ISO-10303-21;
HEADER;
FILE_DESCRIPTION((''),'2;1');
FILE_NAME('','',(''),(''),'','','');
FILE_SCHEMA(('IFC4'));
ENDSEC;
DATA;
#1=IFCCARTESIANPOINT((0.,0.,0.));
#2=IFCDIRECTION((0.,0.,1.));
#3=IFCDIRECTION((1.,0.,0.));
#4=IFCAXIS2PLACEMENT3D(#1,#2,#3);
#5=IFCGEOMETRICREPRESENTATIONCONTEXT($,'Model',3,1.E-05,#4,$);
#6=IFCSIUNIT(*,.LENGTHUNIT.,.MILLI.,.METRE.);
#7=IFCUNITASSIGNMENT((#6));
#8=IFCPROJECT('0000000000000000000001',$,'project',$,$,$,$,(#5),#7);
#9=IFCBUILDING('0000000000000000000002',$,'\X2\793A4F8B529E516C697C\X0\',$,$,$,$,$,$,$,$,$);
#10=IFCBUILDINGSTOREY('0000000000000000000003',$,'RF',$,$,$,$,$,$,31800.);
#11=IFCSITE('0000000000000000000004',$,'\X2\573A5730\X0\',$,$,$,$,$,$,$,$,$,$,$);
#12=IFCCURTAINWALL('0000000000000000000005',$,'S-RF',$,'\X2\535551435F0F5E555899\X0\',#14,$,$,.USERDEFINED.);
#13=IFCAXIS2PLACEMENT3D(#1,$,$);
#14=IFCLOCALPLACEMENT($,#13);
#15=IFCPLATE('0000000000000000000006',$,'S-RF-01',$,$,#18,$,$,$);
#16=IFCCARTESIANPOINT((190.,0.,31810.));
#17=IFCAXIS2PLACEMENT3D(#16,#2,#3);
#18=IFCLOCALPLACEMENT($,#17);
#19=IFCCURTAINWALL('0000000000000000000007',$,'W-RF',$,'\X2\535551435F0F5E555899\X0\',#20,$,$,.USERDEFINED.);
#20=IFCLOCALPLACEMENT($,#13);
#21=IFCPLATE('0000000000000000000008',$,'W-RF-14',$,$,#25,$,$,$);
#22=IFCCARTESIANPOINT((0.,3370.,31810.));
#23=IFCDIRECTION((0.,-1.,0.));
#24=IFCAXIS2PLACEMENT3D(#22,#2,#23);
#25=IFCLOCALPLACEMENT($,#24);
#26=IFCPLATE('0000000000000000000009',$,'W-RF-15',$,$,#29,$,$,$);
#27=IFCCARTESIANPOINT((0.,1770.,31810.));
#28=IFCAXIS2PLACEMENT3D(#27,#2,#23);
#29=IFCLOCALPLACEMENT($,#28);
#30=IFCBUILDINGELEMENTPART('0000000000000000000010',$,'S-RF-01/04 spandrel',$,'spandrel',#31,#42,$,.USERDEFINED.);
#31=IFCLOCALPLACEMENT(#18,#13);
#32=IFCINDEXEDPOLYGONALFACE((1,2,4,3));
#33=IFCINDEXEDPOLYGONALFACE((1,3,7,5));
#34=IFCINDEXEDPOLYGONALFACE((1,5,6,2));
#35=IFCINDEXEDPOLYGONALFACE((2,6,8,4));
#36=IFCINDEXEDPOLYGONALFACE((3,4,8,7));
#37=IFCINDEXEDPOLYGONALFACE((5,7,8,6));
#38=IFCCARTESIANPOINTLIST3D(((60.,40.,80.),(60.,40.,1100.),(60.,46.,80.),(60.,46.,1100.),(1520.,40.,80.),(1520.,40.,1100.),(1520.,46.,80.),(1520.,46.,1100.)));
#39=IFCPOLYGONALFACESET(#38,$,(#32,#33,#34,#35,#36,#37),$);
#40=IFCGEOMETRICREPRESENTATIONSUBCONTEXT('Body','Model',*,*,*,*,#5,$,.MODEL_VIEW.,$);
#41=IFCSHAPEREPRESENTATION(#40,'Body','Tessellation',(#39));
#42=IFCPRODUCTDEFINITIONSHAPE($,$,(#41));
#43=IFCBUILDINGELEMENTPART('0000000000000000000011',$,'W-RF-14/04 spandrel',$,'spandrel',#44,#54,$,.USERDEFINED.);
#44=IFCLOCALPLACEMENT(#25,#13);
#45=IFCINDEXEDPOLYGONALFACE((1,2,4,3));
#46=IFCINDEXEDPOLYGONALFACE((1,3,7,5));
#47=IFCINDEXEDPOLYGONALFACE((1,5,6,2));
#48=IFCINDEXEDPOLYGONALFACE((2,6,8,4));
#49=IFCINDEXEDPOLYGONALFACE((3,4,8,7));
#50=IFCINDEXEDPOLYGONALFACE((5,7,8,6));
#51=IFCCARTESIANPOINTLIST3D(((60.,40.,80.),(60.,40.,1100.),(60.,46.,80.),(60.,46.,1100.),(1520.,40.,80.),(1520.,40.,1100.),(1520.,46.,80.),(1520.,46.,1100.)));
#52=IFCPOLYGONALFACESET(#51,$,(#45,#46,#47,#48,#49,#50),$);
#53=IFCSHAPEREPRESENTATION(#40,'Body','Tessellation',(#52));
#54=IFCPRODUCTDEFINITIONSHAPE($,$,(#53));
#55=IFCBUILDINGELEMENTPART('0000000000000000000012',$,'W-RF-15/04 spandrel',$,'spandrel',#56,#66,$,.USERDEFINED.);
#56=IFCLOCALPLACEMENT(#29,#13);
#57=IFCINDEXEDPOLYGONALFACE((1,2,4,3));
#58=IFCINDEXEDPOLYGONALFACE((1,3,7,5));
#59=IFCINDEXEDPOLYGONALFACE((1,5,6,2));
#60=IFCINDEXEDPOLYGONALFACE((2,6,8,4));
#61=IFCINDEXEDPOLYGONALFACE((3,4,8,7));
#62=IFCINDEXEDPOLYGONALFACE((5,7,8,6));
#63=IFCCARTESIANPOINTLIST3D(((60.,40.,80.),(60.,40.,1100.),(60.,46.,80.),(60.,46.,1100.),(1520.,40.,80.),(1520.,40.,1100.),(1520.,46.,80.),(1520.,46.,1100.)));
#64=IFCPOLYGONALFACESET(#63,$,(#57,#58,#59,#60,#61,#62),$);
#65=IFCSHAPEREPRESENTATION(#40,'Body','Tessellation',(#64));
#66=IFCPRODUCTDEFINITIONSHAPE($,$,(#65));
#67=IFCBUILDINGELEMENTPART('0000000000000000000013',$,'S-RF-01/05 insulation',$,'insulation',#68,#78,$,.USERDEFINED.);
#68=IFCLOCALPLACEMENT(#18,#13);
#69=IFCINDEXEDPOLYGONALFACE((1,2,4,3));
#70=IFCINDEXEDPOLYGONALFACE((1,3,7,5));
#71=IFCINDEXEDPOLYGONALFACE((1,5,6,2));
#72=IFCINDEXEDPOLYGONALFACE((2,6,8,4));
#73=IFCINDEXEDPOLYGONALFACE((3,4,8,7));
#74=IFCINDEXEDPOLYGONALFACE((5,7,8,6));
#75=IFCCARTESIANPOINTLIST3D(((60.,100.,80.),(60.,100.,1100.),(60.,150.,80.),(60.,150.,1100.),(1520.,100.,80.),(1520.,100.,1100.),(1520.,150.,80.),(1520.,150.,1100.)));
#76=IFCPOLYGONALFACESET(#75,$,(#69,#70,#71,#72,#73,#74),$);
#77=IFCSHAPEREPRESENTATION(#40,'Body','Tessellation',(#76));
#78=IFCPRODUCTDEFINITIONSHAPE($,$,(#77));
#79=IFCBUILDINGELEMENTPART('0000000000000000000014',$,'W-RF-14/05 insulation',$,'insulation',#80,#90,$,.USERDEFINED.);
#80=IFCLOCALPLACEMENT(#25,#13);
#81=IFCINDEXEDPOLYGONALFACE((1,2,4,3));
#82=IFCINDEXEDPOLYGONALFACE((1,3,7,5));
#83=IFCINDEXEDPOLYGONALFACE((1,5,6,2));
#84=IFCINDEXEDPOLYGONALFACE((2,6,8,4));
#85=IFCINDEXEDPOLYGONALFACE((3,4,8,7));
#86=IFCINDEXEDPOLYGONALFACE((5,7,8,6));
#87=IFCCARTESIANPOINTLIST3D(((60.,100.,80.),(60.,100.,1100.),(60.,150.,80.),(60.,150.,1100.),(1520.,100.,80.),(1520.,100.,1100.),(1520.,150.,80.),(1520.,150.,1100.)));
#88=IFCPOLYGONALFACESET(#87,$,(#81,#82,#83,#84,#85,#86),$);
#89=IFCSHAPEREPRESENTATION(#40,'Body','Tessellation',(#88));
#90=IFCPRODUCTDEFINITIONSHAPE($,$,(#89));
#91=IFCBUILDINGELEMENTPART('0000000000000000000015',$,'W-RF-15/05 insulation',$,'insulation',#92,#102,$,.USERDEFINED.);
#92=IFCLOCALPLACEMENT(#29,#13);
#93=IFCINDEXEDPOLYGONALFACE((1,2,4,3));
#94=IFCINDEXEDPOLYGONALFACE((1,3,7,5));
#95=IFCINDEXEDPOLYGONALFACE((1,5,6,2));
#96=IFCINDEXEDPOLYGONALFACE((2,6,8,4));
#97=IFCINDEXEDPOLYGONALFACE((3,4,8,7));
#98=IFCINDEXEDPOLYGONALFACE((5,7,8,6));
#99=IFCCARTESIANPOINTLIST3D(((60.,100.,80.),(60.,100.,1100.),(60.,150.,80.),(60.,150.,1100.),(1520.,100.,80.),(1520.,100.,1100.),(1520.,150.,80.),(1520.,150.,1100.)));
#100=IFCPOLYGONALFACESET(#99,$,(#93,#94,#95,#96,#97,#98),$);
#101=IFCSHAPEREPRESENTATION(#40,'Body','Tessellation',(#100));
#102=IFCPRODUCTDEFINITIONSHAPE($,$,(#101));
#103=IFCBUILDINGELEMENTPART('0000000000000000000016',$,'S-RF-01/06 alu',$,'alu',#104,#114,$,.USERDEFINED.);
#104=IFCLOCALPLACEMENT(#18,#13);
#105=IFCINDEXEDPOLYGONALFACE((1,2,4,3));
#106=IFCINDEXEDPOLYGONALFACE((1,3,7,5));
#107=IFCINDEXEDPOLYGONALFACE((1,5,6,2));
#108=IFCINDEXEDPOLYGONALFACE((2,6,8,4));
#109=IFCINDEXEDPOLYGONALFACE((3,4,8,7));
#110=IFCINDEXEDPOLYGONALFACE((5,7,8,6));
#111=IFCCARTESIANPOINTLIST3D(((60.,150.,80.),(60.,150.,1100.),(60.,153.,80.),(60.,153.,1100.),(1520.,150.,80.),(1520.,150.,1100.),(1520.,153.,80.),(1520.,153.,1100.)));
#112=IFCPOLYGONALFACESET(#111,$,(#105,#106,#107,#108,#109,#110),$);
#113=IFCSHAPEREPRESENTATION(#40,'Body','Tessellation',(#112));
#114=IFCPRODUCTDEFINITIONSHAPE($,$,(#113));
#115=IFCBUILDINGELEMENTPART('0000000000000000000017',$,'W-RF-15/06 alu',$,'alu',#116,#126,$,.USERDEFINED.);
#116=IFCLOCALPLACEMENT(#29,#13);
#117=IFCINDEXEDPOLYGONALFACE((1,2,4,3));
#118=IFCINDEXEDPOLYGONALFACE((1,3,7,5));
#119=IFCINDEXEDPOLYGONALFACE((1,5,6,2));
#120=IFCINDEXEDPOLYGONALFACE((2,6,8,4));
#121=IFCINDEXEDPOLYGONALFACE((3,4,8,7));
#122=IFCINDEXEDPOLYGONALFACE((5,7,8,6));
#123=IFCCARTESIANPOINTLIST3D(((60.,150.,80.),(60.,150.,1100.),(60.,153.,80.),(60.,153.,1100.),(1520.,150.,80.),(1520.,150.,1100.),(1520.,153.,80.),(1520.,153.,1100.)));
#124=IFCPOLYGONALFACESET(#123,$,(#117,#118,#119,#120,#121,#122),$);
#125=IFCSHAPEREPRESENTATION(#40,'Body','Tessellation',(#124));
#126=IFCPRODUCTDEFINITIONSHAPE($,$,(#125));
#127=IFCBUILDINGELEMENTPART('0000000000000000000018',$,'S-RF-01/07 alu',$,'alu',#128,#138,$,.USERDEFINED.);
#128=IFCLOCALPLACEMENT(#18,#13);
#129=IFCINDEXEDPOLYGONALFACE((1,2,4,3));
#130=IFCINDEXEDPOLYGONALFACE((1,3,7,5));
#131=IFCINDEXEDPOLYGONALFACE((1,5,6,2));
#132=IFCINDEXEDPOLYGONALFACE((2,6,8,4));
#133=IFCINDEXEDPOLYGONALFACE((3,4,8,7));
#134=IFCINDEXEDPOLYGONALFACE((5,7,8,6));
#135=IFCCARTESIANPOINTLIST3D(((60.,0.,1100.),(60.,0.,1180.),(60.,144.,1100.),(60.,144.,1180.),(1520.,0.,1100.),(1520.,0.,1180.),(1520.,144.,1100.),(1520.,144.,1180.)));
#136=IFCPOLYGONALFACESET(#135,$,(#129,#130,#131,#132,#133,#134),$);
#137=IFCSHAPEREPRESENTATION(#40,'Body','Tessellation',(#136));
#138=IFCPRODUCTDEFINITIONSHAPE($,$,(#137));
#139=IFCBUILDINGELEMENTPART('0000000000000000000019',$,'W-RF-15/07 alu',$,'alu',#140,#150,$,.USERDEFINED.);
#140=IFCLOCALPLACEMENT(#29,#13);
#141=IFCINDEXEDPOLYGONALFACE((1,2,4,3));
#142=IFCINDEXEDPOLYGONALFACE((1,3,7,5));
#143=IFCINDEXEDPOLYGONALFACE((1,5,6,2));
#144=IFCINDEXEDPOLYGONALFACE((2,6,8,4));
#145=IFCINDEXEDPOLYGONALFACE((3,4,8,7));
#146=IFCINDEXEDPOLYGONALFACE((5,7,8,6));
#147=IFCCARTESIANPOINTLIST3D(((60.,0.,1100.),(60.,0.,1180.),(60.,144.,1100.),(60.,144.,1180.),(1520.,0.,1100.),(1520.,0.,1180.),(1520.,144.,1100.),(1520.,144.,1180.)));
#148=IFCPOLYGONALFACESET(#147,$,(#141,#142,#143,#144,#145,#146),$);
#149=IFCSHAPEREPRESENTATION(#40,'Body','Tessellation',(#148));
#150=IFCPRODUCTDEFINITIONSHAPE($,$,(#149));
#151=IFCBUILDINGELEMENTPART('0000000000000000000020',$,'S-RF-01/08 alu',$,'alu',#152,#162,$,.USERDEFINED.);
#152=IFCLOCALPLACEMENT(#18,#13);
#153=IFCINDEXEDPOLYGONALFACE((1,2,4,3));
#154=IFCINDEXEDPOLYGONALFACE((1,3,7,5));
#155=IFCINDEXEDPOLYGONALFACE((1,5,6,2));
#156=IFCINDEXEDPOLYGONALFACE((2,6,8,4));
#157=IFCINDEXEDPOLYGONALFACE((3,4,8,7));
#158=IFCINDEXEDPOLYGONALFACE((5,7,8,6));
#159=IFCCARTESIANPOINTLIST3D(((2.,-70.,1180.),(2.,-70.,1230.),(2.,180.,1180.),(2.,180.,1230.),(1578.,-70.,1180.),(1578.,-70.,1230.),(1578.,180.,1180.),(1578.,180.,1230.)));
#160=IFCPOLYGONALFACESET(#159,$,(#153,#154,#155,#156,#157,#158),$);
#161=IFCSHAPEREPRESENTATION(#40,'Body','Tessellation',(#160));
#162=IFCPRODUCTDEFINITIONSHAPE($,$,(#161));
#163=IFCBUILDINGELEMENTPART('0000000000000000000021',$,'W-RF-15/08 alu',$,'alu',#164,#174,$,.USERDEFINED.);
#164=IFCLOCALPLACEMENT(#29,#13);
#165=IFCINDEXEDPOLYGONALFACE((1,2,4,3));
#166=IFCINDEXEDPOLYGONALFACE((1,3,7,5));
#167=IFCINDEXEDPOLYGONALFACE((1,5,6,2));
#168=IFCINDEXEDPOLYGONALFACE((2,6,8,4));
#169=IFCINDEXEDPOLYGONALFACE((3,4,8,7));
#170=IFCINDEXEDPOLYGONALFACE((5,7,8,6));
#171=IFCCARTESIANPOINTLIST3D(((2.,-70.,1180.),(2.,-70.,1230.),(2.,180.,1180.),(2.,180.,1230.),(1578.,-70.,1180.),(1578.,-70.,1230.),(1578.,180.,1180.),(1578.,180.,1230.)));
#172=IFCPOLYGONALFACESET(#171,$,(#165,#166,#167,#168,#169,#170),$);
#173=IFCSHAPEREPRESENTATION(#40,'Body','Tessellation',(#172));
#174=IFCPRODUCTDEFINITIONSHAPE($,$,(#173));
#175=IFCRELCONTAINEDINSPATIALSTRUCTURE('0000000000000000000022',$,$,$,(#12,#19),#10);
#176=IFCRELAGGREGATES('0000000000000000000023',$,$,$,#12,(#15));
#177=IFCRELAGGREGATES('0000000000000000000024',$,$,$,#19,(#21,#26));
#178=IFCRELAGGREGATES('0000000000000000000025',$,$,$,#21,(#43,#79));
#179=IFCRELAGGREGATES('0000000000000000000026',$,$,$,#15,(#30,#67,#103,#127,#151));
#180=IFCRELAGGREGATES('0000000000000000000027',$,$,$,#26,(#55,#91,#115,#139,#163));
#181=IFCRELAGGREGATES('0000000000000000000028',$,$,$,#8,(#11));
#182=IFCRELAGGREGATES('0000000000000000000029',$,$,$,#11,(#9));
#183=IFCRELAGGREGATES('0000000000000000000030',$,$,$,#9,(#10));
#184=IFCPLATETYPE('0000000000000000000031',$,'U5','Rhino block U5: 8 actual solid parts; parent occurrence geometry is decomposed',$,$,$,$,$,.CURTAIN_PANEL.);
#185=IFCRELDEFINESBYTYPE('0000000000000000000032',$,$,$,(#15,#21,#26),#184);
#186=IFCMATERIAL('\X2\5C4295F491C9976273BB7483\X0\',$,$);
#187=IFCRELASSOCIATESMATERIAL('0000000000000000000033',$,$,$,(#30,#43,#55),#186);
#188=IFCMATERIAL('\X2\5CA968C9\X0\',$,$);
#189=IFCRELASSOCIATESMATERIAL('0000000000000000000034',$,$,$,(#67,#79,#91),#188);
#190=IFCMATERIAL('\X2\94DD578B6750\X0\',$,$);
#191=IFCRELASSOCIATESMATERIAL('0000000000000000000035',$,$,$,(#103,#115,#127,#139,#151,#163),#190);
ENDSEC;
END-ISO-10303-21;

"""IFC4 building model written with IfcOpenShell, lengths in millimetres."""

from ifc_helpers import new_model, si_unit, frame, frame_2d, origin, origin_with_axes, place, context, subcontext, project, spatial, rectangle, extrude, source, transform, mapped, material, type_object, element, aggregate, save


model = new_model("IFC4")

# Units and contexts
model_context = context("Model", 3, precision=1e-05, world=origin_with_axes())
body_context = subcontext(model_context, "Body", "Model", "MODEL_VIEW")
ifc_project = project(units=[si_unit("LENGTHUNIT", "METRE", prefix="MILLI")], contexts=[model_context])

# Site, building, storey
site = spatial("IfcSite", under=ifc_project, Name="场地")
building = spatial("IfcBuilding", under=site, Name="示例办公楼")
storey = spatial("IfcBuildingStorey", under=building, Name="RF", Elevation=31800.0)

# Curtain walls, plates
curtain_wall_1 = element("IfcCurtainWall", 1, inside=storey, Name="S-RF", ObjectType="单元式幕墙", PredefinedType="USERDEFINED")
plate_type = type_object("IfcPlateType", Name="U5", Description="Rhino block U5: 8 actual solid parts; parent occurrence geometry is decomposed", PredefinedType="CURTAIN_PANEL")
plate_1_placement = place(None, frame((190.0, 0.0, 31810.0), z_axis=(0.0, 0.0, 1.0), x_axis=(1.0, 0.0, 0.0)))
plate_1 = element("IfcPlate", 2, at=plate_1_placement, type_object=plate_type, Name="S-RF-01")
ifc_material_1 = material(Name="铝型材")
aggregate(curtain_wall_1, [plate_1])
curtain_wall_2 = element("IfcCurtainWall", 3, inside=storey, Name="W-RF", ObjectType="单元式幕墙", PredefinedType="USERDEFINED")
plate_2_placement = place(None, frame((0.0, 3370.0, 31810.0), z_axis=(0.0, 0.0, 1.0), x_axis=(0.0, -1.0, 0.0)))
plate_2 = element("IfcPlate", 4, at=plate_2_placement, type_object=plate_type, Name="W-RF-14")
plate_3_placement = place(None, frame((0.0, 1770.0, 31810.0), z_axis=(0.0, 0.0, 1.0), x_axis=(0.0, -1.0, 0.0)))
plate_3 = element("IfcPlate", 5, at=plate_3_placement, type_object=plate_type, Name="W-RF-15")
aggregate(curtain_wall_2, [plate_2, plate_3])

# Building element parts
ifc_material_2 = material(Name="层间釉面玻璃")
shared_shape_1 = source(origin(), body_context, "Body", "SweptSolid", [
    extrude(rectangle(XDim=1460.0, YDim=6.0, at=frame_2d((790.0, 43.0))), frame((0.0, 0.0, 80.0)), (0.0, 0.0, 1.0), 1020.0),
])
building_element_part_1_placement = place(plate_1_placement, origin())
building_element_part_1 = element("IfcBuildingElementPart", 6, at=building_element_part_1_placement, material=ifc_material_2, Name="S-RF-01/04 spandrel", ObjectType="spandrel", PredefinedType="USERDEFINED", context=body_context, shape_type="MappedRepresentation", body=[
    mapped(shared_shape_1, transform((0.0, 0.0, 0.0))),
])
building_element_part_2_placement = place(plate_2_placement, origin())
building_element_part_2 = element("IfcBuildingElementPart", 7, at=building_element_part_2_placement, material=ifc_material_2, Name="W-RF-14/04 spandrel", ObjectType="spandrel", PredefinedType="USERDEFINED", context=body_context, shape_type="MappedRepresentation", body=[
    mapped(shared_shape_1, transform((0.0, 0.0, 0.0))),
])
building_element_part_3_placement = place(plate_3_placement, origin())
building_element_part_3 = element("IfcBuildingElementPart", 8, at=building_element_part_3_placement, material=ifc_material_2, Name="W-RF-15/04 spandrel", ObjectType="spandrel", PredefinedType="USERDEFINED", context=body_context, shape_type="MappedRepresentation", body=[
    mapped(shared_shape_1, transform((0.0, 0.0, 0.0))),
])
ifc_material_3 = material(Name="岩棉")
shared_shape_2 = source(origin(), body_context, "Body", "SweptSolid", [
    extrude(rectangle(XDim=1460.0, YDim=50.0, at=frame_2d((790.0, 125.0))), frame((0.0, 0.0, 80.0)), (0.0, 0.0, 1.0), 1020.0),
])
building_element_part_4_placement = place(plate_1_placement, origin())
building_element_part_4 = element("IfcBuildingElementPart", 9, at=building_element_part_4_placement, material=ifc_material_3, Name="S-RF-01/05 insulation", ObjectType="insulation", PredefinedType="USERDEFINED", context=body_context, shape_type="MappedRepresentation", body=[
    mapped(shared_shape_2, transform((0.0, 0.0, 0.0))),
])
building_element_part_5_placement = place(plate_2_placement, origin())
building_element_part_5 = element("IfcBuildingElementPart", 10, at=building_element_part_5_placement, material=ifc_material_3, Name="W-RF-14/05 insulation", ObjectType="insulation", PredefinedType="USERDEFINED", context=body_context, shape_type="MappedRepresentation", body=[
    mapped(shared_shape_2, transform((0.0, 0.0, 0.0))),
])
aggregate(plate_2, [building_element_part_2, building_element_part_5])
building_element_part_6_placement = place(plate_3_placement, origin())
building_element_part_6 = element("IfcBuildingElementPart", 11, at=building_element_part_6_placement, material=ifc_material_3, Name="W-RF-15/05 insulation", ObjectType="insulation", PredefinedType="USERDEFINED", context=body_context, shape_type="MappedRepresentation", body=[
    mapped(shared_shape_2, transform((0.0, 0.0, 0.0))),
])
shared_shape_3 = source(origin(), body_context, "Body", "SweptSolid", [
    extrude(rectangle(XDim=1460.0, YDim=3.0, at=frame_2d((790.0, 151.5))), frame((0.0, 0.0, 80.0)), (0.0, 0.0, 1.0), 1020.0),
])
building_element_part_7_placement = place(plate_1_placement, origin())
building_element_part_7 = element("IfcBuildingElementPart", 12, at=building_element_part_7_placement, material=ifc_material_1, Name="S-RF-01/06 alu", ObjectType="alu", PredefinedType="USERDEFINED", context=body_context, shape_type="MappedRepresentation", body=[
    mapped(shared_shape_3, transform((0.0, 0.0, 0.0))),
])
building_element_part_8_placement = place(plate_3_placement, origin())
building_element_part_8 = element("IfcBuildingElementPart", 13, at=building_element_part_8_placement, material=ifc_material_1, Name="W-RF-15/06 alu", ObjectType="alu", PredefinedType="USERDEFINED", context=body_context, shape_type="MappedRepresentation", body=[
    mapped(shared_shape_3, transform((0.0, 0.0, 0.0))),
])
shared_shape_4 = source(origin(), body_context, "Body", "SweptSolid", [
    extrude(rectangle(XDim=1460.0, YDim=144.0, at=frame_2d((790.0, 72.0))), frame((0.0, 0.0, 1100.0)), (0.0, 0.0, 1.0), 80.0),
])
building_element_part_9_placement = place(plate_1_placement, origin())
building_element_part_9 = element("IfcBuildingElementPart", 14, at=building_element_part_9_placement, material=ifc_material_1, Name="S-RF-01/07 alu", ObjectType="alu", PredefinedType="USERDEFINED", context=body_context, shape_type="MappedRepresentation", body=[
    mapped(shared_shape_4, transform((0.0, 0.0, 0.0))),
])
building_element_part_10_placement = place(plate_3_placement, origin())
building_element_part_10 = element("IfcBuildingElementPart", 15, at=building_element_part_10_placement, material=ifc_material_1, Name="W-RF-15/07 alu", ObjectType="alu", PredefinedType="USERDEFINED", context=body_context, shape_type="MappedRepresentation", body=[
    mapped(shared_shape_4, transform((0.0, 0.0, 0.0))),
])
shared_shape_5 = source(origin(), body_context, "Body", "SweptSolid", [
    extrude(rectangle(XDim=1576.0, YDim=250.0, at=frame_2d((790.0, 55.0))), frame((0.0, 0.0, 1180.0)), (0.0, 0.0, 1.0), 50.0),
])
building_element_part_11_placement = place(plate_1_placement, origin())
building_element_part_11 = element("IfcBuildingElementPart", 16, at=building_element_part_11_placement, material=ifc_material_1, Name="S-RF-01/08 alu", ObjectType="alu", PredefinedType="USERDEFINED", context=body_context, shape_type="MappedRepresentation", body=[
    mapped(shared_shape_5, transform((0.0, 0.0, 0.0))),
])
aggregate(plate_1, [building_element_part_1, building_element_part_4, building_element_part_7, building_element_part_9, building_element_part_11])
building_element_part_12_placement = place(plate_3_placement, origin())
building_element_part_12 = element("IfcBuildingElementPart", 17, at=building_element_part_12_placement, material=ifc_material_1, Name="W-RF-15/08 alu", ObjectType="alu", PredefinedType="USERDEFINED", context=body_context, shape_type="MappedRepresentation", body=[
    mapped(shared_shape_5, transform((0.0, 0.0, 0.0))),
])
aggregate(plate_3, [building_element_part_3, building_element_part_6, building_element_part_8, building_element_part_10, building_element_part_12])

save(model, "model.ifc")
